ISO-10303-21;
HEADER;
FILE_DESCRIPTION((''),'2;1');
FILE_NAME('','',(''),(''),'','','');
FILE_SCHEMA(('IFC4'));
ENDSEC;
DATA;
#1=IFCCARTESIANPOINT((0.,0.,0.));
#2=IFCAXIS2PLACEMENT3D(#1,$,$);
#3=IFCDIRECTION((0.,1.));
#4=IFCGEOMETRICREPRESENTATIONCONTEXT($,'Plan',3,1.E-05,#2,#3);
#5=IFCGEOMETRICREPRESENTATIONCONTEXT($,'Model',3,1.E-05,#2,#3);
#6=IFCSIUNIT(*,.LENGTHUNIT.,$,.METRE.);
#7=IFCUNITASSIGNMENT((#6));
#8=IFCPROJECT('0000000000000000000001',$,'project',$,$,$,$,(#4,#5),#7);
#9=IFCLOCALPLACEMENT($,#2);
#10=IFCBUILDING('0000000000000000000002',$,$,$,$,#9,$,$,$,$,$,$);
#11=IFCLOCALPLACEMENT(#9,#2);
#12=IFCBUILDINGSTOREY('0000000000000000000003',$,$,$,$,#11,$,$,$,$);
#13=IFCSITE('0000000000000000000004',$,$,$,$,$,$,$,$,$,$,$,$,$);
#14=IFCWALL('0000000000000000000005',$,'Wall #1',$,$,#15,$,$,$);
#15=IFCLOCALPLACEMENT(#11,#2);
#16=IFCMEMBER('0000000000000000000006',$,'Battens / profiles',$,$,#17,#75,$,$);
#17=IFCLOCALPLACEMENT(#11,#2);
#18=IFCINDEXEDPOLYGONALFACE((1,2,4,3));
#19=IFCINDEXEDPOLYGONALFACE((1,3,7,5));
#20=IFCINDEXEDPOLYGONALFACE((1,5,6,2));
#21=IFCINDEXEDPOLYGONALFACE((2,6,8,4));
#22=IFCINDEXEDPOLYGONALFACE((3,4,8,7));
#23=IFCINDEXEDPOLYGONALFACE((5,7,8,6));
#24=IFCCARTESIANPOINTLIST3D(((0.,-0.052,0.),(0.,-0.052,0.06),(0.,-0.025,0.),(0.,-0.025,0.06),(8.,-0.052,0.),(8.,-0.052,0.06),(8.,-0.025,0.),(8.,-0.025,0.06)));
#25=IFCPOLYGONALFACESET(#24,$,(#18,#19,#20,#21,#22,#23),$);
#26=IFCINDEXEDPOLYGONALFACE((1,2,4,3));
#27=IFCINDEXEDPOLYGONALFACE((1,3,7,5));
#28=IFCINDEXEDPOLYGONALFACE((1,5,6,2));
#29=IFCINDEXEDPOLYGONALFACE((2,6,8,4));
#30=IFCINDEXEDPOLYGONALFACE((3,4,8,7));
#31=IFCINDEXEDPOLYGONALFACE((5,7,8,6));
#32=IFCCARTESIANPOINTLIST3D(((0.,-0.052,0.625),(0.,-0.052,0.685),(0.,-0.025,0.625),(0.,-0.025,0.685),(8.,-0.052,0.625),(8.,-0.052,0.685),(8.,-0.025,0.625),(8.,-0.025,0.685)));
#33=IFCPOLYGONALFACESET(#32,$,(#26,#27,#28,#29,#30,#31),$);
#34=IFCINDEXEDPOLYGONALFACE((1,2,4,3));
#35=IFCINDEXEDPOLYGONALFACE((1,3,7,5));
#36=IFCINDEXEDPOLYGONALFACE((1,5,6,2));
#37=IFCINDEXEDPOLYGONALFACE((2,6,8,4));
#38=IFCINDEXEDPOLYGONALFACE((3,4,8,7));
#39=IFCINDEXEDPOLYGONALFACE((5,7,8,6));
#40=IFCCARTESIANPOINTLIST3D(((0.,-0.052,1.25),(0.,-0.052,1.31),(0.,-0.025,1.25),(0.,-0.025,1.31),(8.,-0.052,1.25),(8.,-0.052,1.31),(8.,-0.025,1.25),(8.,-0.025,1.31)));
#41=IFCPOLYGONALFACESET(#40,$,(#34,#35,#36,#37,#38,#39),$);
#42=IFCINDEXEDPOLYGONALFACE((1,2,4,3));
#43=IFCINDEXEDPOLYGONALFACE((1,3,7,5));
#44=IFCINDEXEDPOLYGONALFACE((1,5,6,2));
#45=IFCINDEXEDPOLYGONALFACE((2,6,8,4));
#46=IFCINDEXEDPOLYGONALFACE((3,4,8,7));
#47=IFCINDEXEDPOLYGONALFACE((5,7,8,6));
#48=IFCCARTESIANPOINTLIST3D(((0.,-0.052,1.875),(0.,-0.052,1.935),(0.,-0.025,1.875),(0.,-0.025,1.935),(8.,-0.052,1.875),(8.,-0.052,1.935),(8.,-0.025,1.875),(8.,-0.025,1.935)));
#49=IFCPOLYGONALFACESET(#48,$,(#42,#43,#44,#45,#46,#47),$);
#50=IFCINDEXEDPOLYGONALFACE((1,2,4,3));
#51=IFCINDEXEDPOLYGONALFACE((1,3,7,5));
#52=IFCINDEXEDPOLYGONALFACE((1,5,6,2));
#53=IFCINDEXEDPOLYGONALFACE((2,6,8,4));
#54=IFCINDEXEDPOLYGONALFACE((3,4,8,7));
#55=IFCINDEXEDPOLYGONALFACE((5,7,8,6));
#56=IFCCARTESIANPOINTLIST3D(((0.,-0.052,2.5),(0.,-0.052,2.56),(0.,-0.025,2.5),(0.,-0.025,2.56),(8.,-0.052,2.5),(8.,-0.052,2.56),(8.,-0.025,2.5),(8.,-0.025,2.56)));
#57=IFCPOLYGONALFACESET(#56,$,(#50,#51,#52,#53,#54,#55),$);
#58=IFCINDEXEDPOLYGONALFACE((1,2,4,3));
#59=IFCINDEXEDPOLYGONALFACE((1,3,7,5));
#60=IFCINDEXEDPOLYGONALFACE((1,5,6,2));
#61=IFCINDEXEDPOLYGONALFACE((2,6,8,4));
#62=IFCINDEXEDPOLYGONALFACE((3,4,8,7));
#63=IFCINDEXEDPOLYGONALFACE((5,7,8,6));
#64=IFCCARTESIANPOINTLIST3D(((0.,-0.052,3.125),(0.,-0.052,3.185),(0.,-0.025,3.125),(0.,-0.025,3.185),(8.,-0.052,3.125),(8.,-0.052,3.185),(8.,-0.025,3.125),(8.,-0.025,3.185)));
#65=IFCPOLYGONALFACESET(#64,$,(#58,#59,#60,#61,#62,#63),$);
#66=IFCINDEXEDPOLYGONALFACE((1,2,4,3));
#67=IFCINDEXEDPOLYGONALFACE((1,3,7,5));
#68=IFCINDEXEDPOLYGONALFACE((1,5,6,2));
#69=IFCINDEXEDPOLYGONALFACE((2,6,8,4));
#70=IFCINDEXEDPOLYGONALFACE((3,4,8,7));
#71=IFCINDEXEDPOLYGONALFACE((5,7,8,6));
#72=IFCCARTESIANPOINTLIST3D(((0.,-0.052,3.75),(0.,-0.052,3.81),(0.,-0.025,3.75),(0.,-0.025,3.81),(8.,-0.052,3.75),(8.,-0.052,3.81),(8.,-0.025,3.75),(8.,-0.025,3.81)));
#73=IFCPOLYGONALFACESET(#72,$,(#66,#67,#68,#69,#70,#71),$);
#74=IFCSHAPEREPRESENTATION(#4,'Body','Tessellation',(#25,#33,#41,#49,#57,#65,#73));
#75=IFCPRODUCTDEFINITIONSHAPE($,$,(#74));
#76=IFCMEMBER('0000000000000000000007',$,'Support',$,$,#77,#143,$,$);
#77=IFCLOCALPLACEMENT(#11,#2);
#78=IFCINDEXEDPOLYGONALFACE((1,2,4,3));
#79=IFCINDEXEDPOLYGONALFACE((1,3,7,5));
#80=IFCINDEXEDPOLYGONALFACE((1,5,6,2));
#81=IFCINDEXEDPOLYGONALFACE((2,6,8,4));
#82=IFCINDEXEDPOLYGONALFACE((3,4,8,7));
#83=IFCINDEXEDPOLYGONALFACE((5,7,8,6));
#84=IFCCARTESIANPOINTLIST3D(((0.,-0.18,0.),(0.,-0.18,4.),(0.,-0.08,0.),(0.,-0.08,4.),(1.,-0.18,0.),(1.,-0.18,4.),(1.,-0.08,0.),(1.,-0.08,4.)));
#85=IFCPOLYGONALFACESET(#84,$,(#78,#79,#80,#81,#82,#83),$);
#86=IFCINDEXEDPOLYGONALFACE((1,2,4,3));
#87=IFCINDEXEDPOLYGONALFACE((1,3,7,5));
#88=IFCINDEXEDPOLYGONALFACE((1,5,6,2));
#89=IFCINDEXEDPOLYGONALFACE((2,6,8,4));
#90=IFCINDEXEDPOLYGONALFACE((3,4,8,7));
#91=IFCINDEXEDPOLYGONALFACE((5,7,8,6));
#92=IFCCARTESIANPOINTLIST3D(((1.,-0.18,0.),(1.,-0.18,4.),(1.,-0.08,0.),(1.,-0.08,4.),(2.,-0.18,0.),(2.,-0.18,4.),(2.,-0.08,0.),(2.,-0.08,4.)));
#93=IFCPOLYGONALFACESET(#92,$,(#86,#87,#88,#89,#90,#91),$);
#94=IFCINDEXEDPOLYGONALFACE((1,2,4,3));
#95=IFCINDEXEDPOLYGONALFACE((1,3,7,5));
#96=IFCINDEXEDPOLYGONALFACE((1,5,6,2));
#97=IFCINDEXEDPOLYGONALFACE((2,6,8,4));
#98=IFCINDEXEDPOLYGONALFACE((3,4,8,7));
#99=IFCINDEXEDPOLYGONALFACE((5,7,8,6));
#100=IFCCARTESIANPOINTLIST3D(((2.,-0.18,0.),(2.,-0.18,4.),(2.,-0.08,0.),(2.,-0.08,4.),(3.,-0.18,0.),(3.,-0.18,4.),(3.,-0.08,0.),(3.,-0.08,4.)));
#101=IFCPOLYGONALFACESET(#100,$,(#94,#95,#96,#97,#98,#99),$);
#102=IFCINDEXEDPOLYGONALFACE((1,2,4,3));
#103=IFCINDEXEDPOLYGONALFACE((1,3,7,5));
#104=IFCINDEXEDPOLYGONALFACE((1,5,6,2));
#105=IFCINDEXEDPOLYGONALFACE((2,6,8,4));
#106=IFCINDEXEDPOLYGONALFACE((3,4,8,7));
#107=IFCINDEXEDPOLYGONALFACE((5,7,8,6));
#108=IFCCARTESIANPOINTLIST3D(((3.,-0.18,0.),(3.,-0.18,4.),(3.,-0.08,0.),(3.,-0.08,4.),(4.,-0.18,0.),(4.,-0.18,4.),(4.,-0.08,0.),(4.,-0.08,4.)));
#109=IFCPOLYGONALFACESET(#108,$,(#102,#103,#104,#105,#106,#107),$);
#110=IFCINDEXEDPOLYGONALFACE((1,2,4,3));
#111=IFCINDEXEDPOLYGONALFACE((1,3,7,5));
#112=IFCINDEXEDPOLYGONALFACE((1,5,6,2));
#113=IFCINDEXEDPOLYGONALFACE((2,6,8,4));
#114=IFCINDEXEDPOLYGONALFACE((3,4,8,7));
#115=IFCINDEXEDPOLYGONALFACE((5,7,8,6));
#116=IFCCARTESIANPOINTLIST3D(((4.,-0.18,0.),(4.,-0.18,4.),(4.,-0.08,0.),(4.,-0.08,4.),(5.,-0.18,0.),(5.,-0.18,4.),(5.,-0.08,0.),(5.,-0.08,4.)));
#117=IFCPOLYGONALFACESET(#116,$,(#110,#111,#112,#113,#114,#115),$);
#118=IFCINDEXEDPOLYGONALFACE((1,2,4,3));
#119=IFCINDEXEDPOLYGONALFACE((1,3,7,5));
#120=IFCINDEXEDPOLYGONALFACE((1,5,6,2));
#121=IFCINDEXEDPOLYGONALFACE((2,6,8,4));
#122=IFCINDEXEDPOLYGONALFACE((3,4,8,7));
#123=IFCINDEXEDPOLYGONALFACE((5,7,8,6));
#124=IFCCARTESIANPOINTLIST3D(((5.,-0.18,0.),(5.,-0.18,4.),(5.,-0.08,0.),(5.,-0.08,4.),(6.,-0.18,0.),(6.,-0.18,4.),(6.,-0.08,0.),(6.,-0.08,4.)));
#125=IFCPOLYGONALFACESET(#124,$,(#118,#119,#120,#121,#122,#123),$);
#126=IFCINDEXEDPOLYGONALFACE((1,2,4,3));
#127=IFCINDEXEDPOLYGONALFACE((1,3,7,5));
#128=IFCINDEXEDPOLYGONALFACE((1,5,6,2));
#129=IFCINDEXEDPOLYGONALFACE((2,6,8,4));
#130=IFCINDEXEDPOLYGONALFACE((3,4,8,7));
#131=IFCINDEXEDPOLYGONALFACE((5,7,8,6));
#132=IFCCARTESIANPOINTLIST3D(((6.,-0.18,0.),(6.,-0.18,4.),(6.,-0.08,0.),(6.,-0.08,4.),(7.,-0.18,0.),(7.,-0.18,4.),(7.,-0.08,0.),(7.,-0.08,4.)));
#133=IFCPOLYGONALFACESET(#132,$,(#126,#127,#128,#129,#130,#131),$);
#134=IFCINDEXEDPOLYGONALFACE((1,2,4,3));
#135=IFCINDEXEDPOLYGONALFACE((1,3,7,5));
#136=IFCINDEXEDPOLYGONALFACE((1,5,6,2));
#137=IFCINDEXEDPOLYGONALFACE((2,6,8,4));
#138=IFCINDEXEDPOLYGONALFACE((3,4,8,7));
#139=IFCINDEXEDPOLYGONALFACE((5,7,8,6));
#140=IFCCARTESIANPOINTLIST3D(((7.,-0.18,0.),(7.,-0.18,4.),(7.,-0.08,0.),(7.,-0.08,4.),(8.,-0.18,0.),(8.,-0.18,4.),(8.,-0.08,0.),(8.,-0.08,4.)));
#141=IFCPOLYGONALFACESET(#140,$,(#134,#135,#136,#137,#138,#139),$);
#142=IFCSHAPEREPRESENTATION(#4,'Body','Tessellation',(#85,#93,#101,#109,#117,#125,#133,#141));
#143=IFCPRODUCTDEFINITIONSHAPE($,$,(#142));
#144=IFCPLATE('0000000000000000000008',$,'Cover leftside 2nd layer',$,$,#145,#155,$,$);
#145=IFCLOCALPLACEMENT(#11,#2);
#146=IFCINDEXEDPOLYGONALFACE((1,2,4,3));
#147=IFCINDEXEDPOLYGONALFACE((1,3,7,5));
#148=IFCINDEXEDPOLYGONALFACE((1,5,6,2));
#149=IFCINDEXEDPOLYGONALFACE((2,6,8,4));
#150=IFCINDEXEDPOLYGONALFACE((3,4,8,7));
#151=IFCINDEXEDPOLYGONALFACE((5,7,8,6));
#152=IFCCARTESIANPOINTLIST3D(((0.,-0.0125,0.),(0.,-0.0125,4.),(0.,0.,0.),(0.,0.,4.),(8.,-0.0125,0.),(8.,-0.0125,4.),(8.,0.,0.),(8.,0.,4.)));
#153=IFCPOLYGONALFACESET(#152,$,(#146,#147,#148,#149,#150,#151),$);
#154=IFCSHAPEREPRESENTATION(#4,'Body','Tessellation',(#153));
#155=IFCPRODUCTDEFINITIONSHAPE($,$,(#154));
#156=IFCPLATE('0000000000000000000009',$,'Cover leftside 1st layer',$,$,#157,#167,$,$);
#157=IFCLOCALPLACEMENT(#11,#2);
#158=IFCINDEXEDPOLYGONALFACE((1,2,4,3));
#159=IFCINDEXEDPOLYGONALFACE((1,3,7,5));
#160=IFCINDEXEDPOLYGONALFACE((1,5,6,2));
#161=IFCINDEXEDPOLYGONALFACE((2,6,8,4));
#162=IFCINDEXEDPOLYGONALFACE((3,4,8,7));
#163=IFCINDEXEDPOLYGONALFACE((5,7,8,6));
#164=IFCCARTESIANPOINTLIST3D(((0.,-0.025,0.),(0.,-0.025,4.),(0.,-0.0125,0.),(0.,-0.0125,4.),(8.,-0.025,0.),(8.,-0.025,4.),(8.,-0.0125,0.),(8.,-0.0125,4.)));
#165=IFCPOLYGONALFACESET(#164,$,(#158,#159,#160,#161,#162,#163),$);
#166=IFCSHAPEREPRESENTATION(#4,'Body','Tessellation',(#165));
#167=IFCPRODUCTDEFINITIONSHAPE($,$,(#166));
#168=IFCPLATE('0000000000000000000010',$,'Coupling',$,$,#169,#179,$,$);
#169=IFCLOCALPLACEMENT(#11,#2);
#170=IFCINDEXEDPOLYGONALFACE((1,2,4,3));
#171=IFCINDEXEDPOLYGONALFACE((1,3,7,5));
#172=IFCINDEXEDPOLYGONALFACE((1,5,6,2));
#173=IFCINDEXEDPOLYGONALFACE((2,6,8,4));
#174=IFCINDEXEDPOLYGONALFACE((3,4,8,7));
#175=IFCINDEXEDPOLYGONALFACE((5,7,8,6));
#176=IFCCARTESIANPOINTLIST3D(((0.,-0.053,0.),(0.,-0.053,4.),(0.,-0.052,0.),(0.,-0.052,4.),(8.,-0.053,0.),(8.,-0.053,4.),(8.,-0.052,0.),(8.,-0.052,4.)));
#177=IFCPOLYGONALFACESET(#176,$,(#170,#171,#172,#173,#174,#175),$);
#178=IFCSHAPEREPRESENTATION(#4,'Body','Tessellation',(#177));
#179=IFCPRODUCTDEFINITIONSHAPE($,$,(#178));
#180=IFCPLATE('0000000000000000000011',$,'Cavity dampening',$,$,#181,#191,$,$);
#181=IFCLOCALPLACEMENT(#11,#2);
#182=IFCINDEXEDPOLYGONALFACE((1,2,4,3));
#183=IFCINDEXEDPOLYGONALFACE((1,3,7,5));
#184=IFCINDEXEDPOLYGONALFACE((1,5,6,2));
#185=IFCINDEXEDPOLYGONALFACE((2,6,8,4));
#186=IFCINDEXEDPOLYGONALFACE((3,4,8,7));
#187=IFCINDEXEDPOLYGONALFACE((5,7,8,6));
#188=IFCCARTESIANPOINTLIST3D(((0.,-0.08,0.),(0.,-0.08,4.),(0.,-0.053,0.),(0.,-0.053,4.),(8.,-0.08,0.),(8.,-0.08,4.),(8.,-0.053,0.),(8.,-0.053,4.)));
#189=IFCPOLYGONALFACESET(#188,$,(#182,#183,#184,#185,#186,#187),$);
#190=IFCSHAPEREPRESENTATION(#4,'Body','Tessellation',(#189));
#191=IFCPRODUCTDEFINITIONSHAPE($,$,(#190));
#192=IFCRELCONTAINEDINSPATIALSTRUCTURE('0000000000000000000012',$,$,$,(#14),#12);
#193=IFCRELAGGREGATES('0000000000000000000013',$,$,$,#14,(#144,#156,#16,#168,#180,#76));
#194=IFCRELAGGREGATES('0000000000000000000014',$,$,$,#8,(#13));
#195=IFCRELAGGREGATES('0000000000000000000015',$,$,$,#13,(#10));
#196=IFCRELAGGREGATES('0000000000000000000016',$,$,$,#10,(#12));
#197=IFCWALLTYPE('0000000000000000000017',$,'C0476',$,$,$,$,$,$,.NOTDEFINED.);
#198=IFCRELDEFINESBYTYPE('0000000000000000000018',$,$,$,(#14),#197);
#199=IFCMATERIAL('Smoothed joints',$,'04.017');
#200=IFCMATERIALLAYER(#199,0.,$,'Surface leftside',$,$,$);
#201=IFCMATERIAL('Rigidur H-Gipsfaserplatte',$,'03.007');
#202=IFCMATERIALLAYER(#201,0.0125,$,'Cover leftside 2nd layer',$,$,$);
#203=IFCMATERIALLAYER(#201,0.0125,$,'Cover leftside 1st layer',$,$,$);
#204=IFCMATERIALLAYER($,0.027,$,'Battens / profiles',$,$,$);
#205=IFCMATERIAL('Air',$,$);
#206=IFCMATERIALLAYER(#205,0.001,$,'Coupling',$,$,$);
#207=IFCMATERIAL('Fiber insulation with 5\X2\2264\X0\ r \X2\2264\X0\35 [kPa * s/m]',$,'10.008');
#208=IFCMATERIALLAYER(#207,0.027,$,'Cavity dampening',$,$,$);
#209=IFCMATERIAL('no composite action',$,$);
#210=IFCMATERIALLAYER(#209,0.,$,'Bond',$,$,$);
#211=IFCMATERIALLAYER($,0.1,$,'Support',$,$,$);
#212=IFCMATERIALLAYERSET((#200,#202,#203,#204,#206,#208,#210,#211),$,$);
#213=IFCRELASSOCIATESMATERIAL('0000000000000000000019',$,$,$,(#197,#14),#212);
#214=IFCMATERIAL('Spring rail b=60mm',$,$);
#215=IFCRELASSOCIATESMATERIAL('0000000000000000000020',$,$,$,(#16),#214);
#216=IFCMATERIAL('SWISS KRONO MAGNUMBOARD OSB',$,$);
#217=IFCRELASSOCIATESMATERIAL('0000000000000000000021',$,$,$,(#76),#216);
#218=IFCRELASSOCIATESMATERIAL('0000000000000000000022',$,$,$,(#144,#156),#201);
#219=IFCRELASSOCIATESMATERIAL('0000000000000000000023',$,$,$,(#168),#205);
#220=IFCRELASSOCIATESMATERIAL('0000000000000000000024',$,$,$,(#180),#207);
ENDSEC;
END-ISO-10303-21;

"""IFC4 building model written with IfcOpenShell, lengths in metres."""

from ifc_helpers import new_model, si_unit, direction, frame, frame_2d, origin, origin_with_axes, place, context, project, spatial, rectangle, extrude, material, layer, layer_set, type_object, element, aggregate, save


model = new_model("IFC4")

# Units and contexts
plan_context = context("Plan", 3, precision=1e-05, world=origin(), true_north=direction((0.0, 1.0)))
model_context = context("Model", 3, precision=1e-05, world=origin(), true_north=direction((0.0, 1.0)))
ifc_project = project(units=[si_unit("LENGTHUNIT", "METRE")], contexts=[plan_context, model_context])

# Site, building, storey
site = spatial("IfcSite", under=ifc_project)
building_placement = place(None, origin())
building = spatial("IfcBuilding", under=site, at=building_placement)
storey_placement = place(building_placement, origin())
storey = spatial("IfcBuildingStorey", under=building, at=storey_placement)

# Wall, members, plates
ifc_material_1 = material(Name="Smoothed joints", Category="04.017")
ifc_layer_1 = layer(ifc_material_1, 0.0, Name="Surface leftside")
ifc_material_2 = material(Name="Rigidur H-Gipsfaserplatte", Category="03.007")
ifc_layer_2 = layer(ifc_material_2, 0.0125, Name="Cover leftside 2nd layer")
ifc_layer_3 = layer(ifc_material_2, 0.0125, Name="Cover leftside 1st layer")
ifc_layer_4 = layer(None, 0.027, Name="Battens / profiles")
ifc_material_3 = material(Name="Air")
ifc_layer_5 = layer(ifc_material_3, 0.001, Name="Coupling")
ifc_material_4 = material(Name="Fiber insulation with 5≤ r ≤35 [kPa * s/m]", Category="10.008")
ifc_layer_6 = layer(ifc_material_4, 0.027, Name="Cavity dampening")
ifc_material_5 = material(Name="no composite action")
ifc_layer_7 = layer(ifc_material_5, 0.0, Name="Bond")
ifc_layer_8 = layer(None, 0.1, Name="Support")
ifc_layer_set = layer_set([ifc_layer_1, ifc_layer_2, ifc_layer_3, ifc_layer_4, ifc_layer_5, ifc_layer_6, ifc_layer_7, ifc_layer_8])
wall_type = type_object("IfcWallType", Name="C0476", PredefinedType="NOTDEFINED", material=ifc_layer_set)
wall_placement = place(None, frame((0.0, 0.0, 0.0), z_axis=(0.0, -1.0, 0.0), x_axis=(1.0, 0.0, 0.0)))
wall = element("IfcWall", 1, at=wall_placement, inside=storey, type_object=wall_type, material=ifc_layer_set, Name="Wall #1")
ifc_material_6 = material(Name="Spring rail b=60mm")
member_1_placement = place(wall_placement, origin())
member_1 = element("IfcMember", 2, at=member_1_placement, material=ifc_material_6, Name="Battens / profiles", context=plan_context, shape_type="SweptSolid", body=[
    extrude(rectangle(XDim=0.06, YDim=0.027, at=frame_2d((0.03, 0.0135), x_axis=(1.0, 0.0))), frame((0.0, 0.0, 0.025), z_axis=(1.0, 0.0, 0.0), x_axis=(0.0, 1.0, 0.0)), (0.0, 0.0, 1.0), 8.0),
    extrude(rectangle(XDim=0.06, YDim=0.027, at=frame_2d((0.03, 0.0135), x_axis=(1.0, 0.0))), frame((0.0, 0.625, 0.025), z_axis=(1.0, 0.0, 0.0), x_axis=(0.0, 1.0, 0.0)), (0.0, 0.0, 1.0), 8.0),
    extrude(rectangle(XDim=0.06, YDim=0.027, at=frame_2d((0.03, 0.0135), x_axis=(1.0, 0.0))), frame((0.0, 1.25, 0.025), z_axis=(1.0, 0.0, 0.0), x_axis=(0.0, 1.0, 0.0)), (0.0, 0.0, 1.0), 8.0),
    extrude(rectangle(XDim=0.06, YDim=0.027, at=frame_2d((0.03, 0.0135), x_axis=(1.0, 0.0))), frame((0.0, 1.875, 0.025), z_axis=(1.0, 0.0, 0.0), x_axis=(0.0, 1.0, 0.0)), (0.0, 0.0, 1.0), 8.0),
    extrude(rectangle(XDim=0.06, YDim=0.027, at=frame_2d((0.03, 0.0135), x_axis=(1.0, 0.0))), frame((0.0, 2.5, 0.025), z_axis=(1.0, 0.0, 0.0), x_axis=(0.0, 1.0, 0.0)), (0.0, 0.0, 1.0), 8.0),
    extrude(rectangle(XDim=0.06, YDim=0.027, at=frame_2d((0.03, 0.0135), x_axis=(1.0, 0.0))), frame((0.0, 3.125, 0.025), z_axis=(1.0, 0.0, 0.0), x_axis=(0.0, 1.0, 0.0)), (0.0, 0.0, 1.0), 8.0),
    extrude(rectangle(XDim=0.06, YDim=0.027, at=frame_2d((0.03, 0.0135), x_axis=(1.0, 0.0))), frame((0.0, 3.75, 0.025), z_axis=(1.0, 0.0, 0.0), x_axis=(0.0, 1.0, 0.0)), (0.0, 0.0, 1.0), 8.0),
])
ifc_material_7 = material(Name="SWISS KRONO MAGNUMBOARD OSB")
member_2_placement = place(wall_placement, origin())
member_2 = element("IfcMember", 3, at=member_2_placement, material=ifc_material_7, Name="Support", context=plan_context, shape_type="SweptSolid", body=[
    extrude(rectangle(XDim=1.0, YDim=0.1, at=frame_2d((0.5, 0.05), x_axis=(1.0, 0.0))), frame((0.0, 4.0, 0.08), z_axis=(0.0, -1.0, 0.0), x_axis=(1.0, 0.0, 0.0)), (0.0, 0.0, 1.0), 4.0),
    extrude(rectangle(XDim=1.0, YDim=0.1, at=frame_2d((0.5, 0.05), x_axis=(1.0, 0.0))), frame((1.0, 4.0, 0.08), z_axis=(0.0, -1.0, 0.0), x_axis=(1.0, 0.0, 0.0)), (0.0, 0.0, 1.0), 4.0),
    extrude(rectangle(XDim=1.0, YDim=0.1, at=frame_2d((0.5, 0.05), x_axis=(1.0, 0.0))), frame((2.0, 4.0, 0.08), z_axis=(0.0, -1.0, 0.0), x_axis=(1.0, 0.0, 0.0)), (0.0, 0.0, 1.0), 4.0),
    extrude(rectangle(XDim=1.0, YDim=0.1, at=frame_2d((0.5, 0.05), x_axis=(1.0, 0.0))), frame((3.0, 4.0, 0.08), z_axis=(0.0, -1.0, 0.0), x_axis=(1.0, 0.0, 0.0)), (0.0, 0.0, 1.0), 4.0),
    extrude(rectangle(XDim=1.0, YDim=0.1, at=frame_2d((0.5, 0.05), x_axis=(1.0, 0.0))), frame((4.0, 4.0, 0.08), z_axis=(0.0, -1.0, 0.0), x_axis=(1.0, 0.0, 0.0)), (0.0, 0.0, 1.0), 4.0),
    extrude(rectangle(XDim=1.0, YDim=0.1, at=frame_2d((0.5, 0.05), x_axis=(1.0, 0.0))), frame((5.0, 4.0, 0.08), z_axis=(0.0, -1.0, 0.0), x_axis=(1.0, 0.0, 0.0)), (0.0, 0.0, 1.0), 4.0),
    extrude(rectangle(XDim=1.0, YDim=0.1, at=frame_2d((0.5, 0.05), x_axis=(1.0, 0.0))), frame((6.0, 4.0, 0.08), z_axis=(0.0, -1.0, 0.0), x_axis=(1.0, 0.0, 0.0)), (0.0, 0.0, 1.0), 4.0),
    extrude(rectangle(XDim=1.0, YDim=0.1, at=frame_2d((0.5, 0.05), x_axis=(1.0, 0.0))), frame((7.0, 4.0, 0.08), z_axis=(0.0, -1.0, 0.0), x_axis=(1.0, 0.0, 0.0)), (0.0, 0.0, 1.0), 4.0),
])
plate_1_placement = place(wall_placement, origin())
plate_1 = element("IfcPlate", 4, at=plate_1_placement, material=ifc_material_2, Name="Cover leftside 2nd layer", context=plan_context, shape_type="SweptSolid", body=[
    extrude(rectangle(XDim=8.0, YDim=4.0, at=frame_2d((4.0, 2.0), x_axis=(1.0, 0.0))), origin_with_axes(), (0.0, 0.0, 1.0), 0.0125),
])
plate_2_placement = place(wall_placement, origin())
plate_2 = element("IfcPlate", 5, at=plate_2_placement, material=ifc_material_2, Name="Cover leftside 1st layer", context=plan_context, shape_type="SweptSolid", body=[
    extrude(rectangle(XDim=8.0, YDim=4.0, at=frame_2d((4.0, 2.0), x_axis=(1.0, 0.0))), frame((0.0, 0.0, 0.0125), z_axis=(0.0, 0.0, 1.0), x_axis=(1.0, 0.0, 0.0)), (0.0, 0.0, 1.0), 0.0125),
])
plate_3_placement = place(wall_placement, origin())
plate_3 = element("IfcPlate", 6, at=plate_3_placement, material=ifc_material_3, Name="Coupling", context=plan_context, shape_type="SweptSolid", body=[
    extrude(rectangle(XDim=8.0, YDim=4.0, at=frame_2d((4.0, 2.0), x_axis=(1.0, 0.0))), frame((0.0, 0.0, 0.052), z_axis=(0.0, 0.0, 1.0), x_axis=(1.0, 0.0, 0.0)), (0.0, 0.0, 1.0), 0.001),
])
plate_4_placement = place(wall_placement, origin())
plate_4 = element("IfcPlate", 7, at=plate_4_placement, material=ifc_material_4, Name="Cavity dampening", context=plan_context, shape_type="SweptSolid", body=[
    extrude(rectangle(XDim=8.0, YDim=4.0, at=frame_2d((4.0, 2.0), x_axis=(1.0, 0.0))), frame((0.0, 0.0, 0.053), z_axis=(0.0, 0.0, 1.0), x_axis=(1.0, 0.0, 0.0)), (0.0, 0.0, 1.0), 0.027),
])
aggregate(wall, [plate_1, plate_2, member_1, plate_3, plate_4, member_2])

save(model, "model.ifc")
